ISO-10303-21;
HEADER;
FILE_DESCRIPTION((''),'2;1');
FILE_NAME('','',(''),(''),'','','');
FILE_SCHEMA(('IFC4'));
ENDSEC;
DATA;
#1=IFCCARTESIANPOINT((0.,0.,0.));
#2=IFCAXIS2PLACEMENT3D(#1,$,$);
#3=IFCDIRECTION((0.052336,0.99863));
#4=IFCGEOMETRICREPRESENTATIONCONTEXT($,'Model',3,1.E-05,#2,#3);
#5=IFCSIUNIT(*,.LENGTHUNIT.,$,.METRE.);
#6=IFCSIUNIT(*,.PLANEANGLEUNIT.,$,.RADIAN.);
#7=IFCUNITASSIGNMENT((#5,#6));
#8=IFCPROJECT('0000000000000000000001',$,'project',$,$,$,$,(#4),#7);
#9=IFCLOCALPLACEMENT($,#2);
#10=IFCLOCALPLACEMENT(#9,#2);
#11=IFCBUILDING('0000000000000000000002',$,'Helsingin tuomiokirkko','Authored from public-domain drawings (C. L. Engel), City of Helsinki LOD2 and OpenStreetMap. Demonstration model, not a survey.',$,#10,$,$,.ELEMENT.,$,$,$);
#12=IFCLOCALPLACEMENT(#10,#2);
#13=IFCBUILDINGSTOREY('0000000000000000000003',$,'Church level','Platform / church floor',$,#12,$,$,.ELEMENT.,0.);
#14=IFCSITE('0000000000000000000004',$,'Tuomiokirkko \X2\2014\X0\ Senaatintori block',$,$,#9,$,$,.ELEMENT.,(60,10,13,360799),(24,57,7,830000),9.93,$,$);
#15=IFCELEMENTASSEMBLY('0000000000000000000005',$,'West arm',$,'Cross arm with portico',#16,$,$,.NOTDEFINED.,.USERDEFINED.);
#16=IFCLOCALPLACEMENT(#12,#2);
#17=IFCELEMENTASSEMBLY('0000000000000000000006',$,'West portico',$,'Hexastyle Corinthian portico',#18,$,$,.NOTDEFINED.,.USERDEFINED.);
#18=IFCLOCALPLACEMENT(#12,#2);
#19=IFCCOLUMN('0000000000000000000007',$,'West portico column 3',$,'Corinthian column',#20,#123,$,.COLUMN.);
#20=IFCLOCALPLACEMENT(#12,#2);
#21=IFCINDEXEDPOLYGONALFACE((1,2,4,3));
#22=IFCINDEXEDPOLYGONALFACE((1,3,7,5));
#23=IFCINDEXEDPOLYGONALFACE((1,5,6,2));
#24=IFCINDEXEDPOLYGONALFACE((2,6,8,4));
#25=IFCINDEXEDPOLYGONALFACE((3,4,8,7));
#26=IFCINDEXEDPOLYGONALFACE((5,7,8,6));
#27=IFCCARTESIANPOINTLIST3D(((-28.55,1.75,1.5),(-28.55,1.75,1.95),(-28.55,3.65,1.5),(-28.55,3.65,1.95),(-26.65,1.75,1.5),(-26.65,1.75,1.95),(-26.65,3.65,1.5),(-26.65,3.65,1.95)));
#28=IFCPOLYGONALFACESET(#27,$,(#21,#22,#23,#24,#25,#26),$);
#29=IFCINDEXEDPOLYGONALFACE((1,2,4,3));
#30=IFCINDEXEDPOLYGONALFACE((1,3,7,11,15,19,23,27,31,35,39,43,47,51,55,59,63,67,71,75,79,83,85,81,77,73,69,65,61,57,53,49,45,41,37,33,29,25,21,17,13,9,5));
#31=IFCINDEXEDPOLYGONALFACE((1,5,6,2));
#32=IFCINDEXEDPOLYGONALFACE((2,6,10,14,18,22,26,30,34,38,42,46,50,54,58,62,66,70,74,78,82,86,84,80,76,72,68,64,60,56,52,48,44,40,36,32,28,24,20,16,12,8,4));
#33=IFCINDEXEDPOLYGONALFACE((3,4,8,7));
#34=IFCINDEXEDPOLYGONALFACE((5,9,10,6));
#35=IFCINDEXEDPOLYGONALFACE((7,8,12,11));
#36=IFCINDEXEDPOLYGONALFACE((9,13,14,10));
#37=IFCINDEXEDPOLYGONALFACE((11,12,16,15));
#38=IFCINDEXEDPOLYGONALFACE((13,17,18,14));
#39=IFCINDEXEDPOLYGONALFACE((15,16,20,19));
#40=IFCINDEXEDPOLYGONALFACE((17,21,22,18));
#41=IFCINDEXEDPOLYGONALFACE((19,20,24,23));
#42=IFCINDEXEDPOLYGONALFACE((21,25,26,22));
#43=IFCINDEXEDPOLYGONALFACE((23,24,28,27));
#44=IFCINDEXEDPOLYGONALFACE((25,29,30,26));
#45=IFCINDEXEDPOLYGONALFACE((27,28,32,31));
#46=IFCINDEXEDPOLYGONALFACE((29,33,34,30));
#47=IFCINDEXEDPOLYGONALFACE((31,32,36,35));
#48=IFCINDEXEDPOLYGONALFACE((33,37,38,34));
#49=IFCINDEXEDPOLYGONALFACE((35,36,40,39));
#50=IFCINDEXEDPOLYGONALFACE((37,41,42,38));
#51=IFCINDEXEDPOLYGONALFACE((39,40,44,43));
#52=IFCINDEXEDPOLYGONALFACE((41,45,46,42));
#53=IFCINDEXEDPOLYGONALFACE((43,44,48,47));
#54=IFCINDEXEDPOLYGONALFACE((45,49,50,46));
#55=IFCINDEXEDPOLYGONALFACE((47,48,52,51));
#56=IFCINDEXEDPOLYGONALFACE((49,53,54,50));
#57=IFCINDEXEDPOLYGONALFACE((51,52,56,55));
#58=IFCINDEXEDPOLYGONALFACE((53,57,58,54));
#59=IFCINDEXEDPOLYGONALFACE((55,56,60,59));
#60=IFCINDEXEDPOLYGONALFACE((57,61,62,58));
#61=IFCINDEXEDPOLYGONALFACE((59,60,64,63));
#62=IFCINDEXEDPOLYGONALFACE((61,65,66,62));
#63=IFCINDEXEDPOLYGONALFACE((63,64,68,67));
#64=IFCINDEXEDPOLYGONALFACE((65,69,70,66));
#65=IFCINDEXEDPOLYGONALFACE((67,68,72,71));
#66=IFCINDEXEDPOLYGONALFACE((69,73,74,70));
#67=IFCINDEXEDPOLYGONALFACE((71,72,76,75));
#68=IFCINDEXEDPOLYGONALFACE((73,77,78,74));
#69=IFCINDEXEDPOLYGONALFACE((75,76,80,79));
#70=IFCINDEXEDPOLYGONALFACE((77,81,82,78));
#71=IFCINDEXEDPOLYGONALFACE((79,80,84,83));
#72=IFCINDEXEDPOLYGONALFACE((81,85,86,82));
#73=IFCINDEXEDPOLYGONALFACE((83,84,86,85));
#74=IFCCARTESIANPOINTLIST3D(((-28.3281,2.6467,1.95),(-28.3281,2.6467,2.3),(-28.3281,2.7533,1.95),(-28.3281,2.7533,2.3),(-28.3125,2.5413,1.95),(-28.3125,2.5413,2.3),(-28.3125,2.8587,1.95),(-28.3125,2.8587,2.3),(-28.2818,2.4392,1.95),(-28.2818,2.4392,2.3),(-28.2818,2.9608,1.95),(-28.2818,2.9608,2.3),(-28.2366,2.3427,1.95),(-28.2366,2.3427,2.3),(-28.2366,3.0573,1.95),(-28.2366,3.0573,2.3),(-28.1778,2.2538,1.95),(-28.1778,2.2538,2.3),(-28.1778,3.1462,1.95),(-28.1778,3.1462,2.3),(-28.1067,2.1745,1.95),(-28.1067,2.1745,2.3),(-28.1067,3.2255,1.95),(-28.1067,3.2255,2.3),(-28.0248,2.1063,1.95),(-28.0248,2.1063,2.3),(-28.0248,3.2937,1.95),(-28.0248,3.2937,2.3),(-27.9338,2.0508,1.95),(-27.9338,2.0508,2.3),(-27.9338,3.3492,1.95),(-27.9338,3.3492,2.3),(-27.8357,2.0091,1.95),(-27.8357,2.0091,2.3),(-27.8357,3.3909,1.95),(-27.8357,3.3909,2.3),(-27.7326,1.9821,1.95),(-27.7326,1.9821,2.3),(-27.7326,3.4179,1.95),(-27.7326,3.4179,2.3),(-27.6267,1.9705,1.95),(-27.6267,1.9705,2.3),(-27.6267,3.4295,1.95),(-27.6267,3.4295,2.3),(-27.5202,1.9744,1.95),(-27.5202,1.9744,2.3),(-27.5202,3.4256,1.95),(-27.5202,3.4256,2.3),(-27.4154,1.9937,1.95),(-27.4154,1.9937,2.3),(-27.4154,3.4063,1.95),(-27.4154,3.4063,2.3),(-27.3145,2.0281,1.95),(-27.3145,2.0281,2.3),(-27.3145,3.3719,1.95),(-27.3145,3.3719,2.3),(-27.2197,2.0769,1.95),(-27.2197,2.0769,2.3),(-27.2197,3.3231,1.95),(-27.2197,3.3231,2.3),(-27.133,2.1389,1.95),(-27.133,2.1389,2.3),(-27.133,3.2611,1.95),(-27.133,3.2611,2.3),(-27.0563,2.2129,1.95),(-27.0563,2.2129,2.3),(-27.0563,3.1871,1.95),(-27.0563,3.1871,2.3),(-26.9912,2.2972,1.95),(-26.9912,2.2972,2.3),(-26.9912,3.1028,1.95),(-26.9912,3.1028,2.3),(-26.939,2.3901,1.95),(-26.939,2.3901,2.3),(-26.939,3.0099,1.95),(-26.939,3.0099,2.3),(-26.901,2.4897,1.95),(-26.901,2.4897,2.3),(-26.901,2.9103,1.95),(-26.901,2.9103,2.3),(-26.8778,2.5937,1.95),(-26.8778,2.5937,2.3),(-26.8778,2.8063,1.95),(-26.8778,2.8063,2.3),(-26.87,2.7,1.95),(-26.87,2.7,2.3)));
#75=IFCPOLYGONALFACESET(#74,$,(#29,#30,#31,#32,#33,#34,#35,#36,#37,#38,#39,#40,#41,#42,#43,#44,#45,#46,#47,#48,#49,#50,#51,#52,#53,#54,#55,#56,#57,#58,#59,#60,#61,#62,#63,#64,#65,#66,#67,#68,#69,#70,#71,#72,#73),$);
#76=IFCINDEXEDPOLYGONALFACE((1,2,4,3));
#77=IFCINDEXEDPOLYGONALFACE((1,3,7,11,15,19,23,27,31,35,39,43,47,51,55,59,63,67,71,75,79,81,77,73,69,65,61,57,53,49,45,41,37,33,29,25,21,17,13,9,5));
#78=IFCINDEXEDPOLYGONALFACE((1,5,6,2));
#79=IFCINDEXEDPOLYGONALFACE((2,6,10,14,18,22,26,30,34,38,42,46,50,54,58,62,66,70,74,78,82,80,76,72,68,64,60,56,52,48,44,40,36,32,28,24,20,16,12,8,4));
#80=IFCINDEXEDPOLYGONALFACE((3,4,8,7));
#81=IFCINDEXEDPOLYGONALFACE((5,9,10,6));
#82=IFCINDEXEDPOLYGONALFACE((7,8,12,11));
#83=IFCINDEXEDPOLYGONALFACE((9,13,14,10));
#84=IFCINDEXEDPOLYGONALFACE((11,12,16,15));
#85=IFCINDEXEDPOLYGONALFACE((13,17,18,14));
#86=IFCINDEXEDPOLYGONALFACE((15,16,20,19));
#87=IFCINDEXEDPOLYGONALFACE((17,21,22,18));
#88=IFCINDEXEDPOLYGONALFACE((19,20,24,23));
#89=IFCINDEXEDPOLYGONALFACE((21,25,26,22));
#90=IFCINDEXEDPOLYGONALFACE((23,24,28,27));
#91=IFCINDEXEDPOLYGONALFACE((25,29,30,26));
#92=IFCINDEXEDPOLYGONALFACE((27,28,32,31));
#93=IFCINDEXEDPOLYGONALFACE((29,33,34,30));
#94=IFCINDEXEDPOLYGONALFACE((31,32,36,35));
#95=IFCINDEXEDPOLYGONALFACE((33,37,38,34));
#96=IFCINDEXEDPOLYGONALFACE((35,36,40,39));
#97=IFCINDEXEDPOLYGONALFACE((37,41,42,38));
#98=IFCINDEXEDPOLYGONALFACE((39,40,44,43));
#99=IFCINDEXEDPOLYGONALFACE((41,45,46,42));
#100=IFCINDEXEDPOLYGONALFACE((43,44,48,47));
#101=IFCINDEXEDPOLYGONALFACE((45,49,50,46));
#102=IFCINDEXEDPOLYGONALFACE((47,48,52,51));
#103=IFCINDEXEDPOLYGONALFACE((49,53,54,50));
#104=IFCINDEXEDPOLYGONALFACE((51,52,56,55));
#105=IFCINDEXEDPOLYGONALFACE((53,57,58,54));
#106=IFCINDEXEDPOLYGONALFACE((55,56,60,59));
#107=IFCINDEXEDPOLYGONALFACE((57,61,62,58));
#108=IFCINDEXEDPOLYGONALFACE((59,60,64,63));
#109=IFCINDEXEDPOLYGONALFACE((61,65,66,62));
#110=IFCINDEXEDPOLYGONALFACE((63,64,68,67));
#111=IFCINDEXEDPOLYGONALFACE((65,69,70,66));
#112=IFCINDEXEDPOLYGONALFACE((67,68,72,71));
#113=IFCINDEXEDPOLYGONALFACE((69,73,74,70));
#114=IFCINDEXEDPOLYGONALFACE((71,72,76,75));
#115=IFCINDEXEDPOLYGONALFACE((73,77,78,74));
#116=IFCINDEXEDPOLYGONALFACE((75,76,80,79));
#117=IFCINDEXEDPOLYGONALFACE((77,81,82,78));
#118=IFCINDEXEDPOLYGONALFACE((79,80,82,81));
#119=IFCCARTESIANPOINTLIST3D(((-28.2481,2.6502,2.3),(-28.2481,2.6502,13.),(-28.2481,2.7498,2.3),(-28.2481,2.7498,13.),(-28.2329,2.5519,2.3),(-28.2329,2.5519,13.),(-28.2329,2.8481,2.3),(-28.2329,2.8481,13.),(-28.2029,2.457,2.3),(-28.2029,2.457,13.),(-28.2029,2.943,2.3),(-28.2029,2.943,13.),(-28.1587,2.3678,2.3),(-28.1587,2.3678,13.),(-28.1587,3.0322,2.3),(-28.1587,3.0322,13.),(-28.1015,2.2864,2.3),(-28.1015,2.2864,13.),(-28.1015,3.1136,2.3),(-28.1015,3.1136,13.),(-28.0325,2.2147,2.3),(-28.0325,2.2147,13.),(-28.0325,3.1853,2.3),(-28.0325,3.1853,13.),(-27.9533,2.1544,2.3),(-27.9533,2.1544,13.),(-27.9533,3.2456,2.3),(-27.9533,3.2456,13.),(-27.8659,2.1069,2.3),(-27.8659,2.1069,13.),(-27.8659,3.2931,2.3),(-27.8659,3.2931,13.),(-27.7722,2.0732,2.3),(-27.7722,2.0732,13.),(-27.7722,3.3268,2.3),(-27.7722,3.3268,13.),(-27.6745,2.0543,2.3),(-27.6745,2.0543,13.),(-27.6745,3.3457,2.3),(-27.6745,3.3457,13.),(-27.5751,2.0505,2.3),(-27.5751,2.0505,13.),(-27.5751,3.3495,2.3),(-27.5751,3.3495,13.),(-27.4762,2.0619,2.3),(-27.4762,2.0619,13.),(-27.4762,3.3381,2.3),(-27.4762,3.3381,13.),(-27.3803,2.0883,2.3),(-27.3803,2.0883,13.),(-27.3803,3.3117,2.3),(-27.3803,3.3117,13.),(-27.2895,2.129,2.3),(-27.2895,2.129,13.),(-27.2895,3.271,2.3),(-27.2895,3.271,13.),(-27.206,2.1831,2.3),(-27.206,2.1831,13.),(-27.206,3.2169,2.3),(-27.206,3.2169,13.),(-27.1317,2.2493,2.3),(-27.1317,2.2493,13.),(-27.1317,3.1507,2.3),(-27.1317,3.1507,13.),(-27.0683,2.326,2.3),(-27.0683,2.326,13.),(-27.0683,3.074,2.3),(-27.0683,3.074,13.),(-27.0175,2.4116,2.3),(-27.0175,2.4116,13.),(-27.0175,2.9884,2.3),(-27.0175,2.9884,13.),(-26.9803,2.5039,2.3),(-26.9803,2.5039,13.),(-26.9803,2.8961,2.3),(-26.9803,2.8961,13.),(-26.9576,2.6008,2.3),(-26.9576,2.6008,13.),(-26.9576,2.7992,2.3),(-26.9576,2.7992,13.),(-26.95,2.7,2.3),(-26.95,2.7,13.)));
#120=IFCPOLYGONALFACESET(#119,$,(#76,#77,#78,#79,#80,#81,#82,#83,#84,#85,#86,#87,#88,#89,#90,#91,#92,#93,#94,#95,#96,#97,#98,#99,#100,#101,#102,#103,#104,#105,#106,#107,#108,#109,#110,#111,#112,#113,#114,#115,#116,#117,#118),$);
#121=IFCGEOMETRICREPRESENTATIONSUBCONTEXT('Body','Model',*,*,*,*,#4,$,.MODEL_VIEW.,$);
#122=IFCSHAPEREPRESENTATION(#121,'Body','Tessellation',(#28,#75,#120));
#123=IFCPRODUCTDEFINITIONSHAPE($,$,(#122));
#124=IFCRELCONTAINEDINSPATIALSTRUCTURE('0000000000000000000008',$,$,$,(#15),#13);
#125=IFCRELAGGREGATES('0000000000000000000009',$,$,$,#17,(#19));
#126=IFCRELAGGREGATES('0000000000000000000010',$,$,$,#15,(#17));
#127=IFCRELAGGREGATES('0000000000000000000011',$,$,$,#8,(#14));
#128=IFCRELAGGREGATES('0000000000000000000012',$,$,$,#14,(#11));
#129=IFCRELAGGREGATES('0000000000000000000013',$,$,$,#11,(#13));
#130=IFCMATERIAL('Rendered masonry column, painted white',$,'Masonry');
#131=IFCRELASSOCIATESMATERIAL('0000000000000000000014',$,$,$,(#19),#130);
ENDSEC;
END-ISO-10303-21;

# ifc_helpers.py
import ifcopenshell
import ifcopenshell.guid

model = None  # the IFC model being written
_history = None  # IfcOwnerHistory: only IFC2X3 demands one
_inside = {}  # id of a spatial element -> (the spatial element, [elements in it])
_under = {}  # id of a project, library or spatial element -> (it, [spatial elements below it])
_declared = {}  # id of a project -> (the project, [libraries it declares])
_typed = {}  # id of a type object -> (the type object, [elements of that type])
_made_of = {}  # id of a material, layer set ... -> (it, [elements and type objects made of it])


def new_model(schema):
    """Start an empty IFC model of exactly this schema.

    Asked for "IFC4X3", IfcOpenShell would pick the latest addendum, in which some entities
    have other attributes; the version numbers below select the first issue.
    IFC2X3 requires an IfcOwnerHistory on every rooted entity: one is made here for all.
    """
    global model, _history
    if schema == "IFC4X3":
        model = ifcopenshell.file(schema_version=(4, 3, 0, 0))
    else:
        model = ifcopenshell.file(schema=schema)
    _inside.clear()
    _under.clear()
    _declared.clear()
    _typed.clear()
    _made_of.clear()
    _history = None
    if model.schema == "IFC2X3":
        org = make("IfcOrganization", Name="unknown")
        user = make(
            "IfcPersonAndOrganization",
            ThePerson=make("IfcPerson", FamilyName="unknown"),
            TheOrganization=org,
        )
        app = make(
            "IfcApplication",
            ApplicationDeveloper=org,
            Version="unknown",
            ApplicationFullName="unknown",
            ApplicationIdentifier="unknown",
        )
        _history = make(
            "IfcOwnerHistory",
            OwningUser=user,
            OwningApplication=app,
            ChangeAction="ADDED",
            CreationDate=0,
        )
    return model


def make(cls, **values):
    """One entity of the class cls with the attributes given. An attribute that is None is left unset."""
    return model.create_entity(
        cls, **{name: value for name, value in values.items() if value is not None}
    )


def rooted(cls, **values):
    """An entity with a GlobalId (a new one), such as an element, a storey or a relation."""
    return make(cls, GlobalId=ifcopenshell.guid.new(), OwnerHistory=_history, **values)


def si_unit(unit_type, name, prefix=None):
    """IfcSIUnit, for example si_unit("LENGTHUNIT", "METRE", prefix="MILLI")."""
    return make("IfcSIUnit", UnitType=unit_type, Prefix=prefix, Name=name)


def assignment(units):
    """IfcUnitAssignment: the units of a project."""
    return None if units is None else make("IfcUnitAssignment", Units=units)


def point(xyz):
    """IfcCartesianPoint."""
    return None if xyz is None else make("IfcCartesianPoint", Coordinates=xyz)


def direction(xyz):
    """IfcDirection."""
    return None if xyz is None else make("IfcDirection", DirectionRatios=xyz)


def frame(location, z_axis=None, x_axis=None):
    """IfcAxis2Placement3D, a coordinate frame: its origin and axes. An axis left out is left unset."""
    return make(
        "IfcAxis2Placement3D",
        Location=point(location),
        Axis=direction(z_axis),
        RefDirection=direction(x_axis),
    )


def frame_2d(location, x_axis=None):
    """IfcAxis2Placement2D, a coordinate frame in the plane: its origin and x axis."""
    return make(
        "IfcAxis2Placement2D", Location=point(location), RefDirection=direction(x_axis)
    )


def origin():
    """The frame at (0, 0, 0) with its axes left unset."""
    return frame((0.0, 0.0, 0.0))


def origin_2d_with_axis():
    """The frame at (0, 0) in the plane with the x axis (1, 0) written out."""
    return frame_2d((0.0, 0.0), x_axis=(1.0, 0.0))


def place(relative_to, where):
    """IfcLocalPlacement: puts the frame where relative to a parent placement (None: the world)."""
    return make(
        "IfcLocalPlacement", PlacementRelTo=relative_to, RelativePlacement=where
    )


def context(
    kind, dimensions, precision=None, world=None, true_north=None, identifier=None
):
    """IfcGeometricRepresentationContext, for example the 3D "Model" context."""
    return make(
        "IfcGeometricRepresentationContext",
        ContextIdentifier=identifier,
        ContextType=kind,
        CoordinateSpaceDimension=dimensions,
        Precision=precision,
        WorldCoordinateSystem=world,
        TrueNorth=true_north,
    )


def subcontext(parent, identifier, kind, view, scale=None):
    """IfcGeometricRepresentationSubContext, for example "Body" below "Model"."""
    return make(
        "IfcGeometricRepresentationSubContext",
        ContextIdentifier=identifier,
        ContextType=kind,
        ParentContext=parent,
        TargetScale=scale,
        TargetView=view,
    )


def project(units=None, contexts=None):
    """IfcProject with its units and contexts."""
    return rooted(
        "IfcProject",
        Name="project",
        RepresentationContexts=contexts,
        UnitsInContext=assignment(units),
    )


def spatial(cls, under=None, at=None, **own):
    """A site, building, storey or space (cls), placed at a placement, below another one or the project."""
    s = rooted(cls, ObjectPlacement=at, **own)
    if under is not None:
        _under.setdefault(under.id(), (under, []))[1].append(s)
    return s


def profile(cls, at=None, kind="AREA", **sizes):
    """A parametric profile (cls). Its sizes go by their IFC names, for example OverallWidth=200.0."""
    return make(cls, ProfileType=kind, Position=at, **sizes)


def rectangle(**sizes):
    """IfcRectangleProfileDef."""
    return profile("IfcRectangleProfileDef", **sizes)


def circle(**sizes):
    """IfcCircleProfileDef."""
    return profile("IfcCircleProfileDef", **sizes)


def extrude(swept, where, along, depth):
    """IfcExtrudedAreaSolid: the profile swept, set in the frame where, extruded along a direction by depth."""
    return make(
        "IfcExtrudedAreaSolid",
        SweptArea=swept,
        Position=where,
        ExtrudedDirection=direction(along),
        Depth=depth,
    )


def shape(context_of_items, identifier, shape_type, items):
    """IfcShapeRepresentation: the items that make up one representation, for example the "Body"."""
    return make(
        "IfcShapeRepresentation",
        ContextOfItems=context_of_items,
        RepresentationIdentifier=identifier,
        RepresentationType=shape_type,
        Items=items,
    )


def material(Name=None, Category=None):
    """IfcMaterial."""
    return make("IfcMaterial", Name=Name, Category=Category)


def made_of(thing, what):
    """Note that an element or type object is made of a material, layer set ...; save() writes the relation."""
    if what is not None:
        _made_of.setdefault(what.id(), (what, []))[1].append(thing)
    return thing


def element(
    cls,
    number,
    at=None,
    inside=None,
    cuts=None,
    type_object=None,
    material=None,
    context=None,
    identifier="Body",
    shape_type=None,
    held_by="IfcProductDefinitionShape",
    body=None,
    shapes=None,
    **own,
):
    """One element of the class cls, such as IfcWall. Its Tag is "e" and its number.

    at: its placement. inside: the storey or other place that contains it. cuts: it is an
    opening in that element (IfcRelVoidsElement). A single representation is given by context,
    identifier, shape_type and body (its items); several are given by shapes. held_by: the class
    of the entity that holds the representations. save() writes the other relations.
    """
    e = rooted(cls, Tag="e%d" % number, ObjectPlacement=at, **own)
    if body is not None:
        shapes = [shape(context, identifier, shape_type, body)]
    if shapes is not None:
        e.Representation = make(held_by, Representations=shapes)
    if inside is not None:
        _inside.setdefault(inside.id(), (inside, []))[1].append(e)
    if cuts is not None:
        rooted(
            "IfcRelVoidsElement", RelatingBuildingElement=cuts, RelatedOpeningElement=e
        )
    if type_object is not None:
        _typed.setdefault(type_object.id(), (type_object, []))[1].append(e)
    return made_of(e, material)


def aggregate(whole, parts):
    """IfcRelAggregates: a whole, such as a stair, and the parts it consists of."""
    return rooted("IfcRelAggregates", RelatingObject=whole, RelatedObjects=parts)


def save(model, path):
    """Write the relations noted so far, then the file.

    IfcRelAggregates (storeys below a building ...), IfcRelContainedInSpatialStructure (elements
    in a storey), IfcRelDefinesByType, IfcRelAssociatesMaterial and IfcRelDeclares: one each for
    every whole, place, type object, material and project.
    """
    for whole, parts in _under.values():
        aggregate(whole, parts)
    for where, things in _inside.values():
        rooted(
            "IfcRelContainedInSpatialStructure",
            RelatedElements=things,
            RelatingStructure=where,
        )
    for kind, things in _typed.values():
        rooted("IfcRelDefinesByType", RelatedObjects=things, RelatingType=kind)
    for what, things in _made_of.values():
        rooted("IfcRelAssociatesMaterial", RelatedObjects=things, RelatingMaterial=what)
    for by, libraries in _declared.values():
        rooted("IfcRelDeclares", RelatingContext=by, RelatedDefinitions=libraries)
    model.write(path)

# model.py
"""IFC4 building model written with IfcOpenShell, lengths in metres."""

from ifc_helpers import new_model, si_unit, direction, frame, origin, origin_2d_with_axis, place, context, subcontext, project, spatial, rectangle, circle, extrude, material, element, aggregate, save


model = new_model("IFC4")

# Units and contexts
model_context = context("Model", 3, precision=1e-05, world=origin(), true_north=direction((0.052336, 0.99863)))
body_context = subcontext(model_context, "Body", "Model", "MODEL_VIEW")
ifc_project = project(units=[si_unit("LENGTHUNIT", "METRE"), si_unit("PLANEANGLEUNIT", "RADIAN")], contexts=[model_context])

# Site, building, storey
site_placement = place(None, origin())
site = spatial("IfcSite", under=ifc_project, at=site_placement, Name="Tuomiokirkko — Senaatintori block", CompositionType="ELEMENT", RefLatitude=(60, 10, 13, 360799), RefLongitude=(24, 57, 7, 830000), RefElevation=9.93)
building_placement = place(site_placement, origin())
building = spatial("IfcBuilding", under=site, at=building_placement, Name="Helsingin tuomiokirkko", Description="Authored from public-domain drawings (C. L. Engel), City of Helsinki LOD2 and OpenStreetMap. Demonstration model, not a survey.", CompositionType="ELEMENT")
storey_placement = place(building_placement, origin())
storey = spatial("IfcBuildingStorey", under=building, at=storey_placement, Name="Church level", Description="Platform / church floor", CompositionType="ELEMENT", Elevation=0.0)

# Element assemblies, column
assembly_1_placement = place(building_placement, origin())
assembly_1 = element("IfcElementAssembly", 1, at=assembly_1_placement, inside=storey, Name="West arm", ObjectType="Cross arm with portico", AssemblyPlace="NOTDEFINED", PredefinedType="USERDEFINED")
assembly_2_placement = place(building_placement, origin())
assembly_2 = element("IfcElementAssembly", 2, at=assembly_2_placement, Name="West portico", ObjectType="Hexastyle Corinthian portico", AssemblyPlace="NOTDEFINED", PredefinedType="USERDEFINED")
ifc_material_1 = material(Name="Rendered masonry column, painted white", Category="Masonry")
column_1_placement = place(building_placement, origin())
column_1 = element("IfcColumn", 3, at=column_1_placement, material=ifc_material_1, Name="West portico column 3", ObjectType="Corinthian column", PredefinedType="COLUMN", context=body_context, shape_type="SweptSolid", body=[
    extrude(rectangle(XDim=1.9, YDim=1.9, at=origin_2d_with_axis()), frame((-27.6, 2.7, 1.5)), (0.0, 0.0, 1.0), 0.45),
    extrude(circle(Radius=0.73, at=origin_2d_with_axis()), frame((-27.6, 2.7, 1.95)), (0.0, 0.0, 1.0), 0.35),
    extrude(circle(Radius=0.65, at=origin_2d_with_axis()), frame((-27.6, 2.7, 2.3)), (0.0, 0.0, 1.0), 10.7),
])

aggregate(assembly_2, [column_1])

aggregate(assembly_1, [assembly_2])

save(model, "model.ifc")
